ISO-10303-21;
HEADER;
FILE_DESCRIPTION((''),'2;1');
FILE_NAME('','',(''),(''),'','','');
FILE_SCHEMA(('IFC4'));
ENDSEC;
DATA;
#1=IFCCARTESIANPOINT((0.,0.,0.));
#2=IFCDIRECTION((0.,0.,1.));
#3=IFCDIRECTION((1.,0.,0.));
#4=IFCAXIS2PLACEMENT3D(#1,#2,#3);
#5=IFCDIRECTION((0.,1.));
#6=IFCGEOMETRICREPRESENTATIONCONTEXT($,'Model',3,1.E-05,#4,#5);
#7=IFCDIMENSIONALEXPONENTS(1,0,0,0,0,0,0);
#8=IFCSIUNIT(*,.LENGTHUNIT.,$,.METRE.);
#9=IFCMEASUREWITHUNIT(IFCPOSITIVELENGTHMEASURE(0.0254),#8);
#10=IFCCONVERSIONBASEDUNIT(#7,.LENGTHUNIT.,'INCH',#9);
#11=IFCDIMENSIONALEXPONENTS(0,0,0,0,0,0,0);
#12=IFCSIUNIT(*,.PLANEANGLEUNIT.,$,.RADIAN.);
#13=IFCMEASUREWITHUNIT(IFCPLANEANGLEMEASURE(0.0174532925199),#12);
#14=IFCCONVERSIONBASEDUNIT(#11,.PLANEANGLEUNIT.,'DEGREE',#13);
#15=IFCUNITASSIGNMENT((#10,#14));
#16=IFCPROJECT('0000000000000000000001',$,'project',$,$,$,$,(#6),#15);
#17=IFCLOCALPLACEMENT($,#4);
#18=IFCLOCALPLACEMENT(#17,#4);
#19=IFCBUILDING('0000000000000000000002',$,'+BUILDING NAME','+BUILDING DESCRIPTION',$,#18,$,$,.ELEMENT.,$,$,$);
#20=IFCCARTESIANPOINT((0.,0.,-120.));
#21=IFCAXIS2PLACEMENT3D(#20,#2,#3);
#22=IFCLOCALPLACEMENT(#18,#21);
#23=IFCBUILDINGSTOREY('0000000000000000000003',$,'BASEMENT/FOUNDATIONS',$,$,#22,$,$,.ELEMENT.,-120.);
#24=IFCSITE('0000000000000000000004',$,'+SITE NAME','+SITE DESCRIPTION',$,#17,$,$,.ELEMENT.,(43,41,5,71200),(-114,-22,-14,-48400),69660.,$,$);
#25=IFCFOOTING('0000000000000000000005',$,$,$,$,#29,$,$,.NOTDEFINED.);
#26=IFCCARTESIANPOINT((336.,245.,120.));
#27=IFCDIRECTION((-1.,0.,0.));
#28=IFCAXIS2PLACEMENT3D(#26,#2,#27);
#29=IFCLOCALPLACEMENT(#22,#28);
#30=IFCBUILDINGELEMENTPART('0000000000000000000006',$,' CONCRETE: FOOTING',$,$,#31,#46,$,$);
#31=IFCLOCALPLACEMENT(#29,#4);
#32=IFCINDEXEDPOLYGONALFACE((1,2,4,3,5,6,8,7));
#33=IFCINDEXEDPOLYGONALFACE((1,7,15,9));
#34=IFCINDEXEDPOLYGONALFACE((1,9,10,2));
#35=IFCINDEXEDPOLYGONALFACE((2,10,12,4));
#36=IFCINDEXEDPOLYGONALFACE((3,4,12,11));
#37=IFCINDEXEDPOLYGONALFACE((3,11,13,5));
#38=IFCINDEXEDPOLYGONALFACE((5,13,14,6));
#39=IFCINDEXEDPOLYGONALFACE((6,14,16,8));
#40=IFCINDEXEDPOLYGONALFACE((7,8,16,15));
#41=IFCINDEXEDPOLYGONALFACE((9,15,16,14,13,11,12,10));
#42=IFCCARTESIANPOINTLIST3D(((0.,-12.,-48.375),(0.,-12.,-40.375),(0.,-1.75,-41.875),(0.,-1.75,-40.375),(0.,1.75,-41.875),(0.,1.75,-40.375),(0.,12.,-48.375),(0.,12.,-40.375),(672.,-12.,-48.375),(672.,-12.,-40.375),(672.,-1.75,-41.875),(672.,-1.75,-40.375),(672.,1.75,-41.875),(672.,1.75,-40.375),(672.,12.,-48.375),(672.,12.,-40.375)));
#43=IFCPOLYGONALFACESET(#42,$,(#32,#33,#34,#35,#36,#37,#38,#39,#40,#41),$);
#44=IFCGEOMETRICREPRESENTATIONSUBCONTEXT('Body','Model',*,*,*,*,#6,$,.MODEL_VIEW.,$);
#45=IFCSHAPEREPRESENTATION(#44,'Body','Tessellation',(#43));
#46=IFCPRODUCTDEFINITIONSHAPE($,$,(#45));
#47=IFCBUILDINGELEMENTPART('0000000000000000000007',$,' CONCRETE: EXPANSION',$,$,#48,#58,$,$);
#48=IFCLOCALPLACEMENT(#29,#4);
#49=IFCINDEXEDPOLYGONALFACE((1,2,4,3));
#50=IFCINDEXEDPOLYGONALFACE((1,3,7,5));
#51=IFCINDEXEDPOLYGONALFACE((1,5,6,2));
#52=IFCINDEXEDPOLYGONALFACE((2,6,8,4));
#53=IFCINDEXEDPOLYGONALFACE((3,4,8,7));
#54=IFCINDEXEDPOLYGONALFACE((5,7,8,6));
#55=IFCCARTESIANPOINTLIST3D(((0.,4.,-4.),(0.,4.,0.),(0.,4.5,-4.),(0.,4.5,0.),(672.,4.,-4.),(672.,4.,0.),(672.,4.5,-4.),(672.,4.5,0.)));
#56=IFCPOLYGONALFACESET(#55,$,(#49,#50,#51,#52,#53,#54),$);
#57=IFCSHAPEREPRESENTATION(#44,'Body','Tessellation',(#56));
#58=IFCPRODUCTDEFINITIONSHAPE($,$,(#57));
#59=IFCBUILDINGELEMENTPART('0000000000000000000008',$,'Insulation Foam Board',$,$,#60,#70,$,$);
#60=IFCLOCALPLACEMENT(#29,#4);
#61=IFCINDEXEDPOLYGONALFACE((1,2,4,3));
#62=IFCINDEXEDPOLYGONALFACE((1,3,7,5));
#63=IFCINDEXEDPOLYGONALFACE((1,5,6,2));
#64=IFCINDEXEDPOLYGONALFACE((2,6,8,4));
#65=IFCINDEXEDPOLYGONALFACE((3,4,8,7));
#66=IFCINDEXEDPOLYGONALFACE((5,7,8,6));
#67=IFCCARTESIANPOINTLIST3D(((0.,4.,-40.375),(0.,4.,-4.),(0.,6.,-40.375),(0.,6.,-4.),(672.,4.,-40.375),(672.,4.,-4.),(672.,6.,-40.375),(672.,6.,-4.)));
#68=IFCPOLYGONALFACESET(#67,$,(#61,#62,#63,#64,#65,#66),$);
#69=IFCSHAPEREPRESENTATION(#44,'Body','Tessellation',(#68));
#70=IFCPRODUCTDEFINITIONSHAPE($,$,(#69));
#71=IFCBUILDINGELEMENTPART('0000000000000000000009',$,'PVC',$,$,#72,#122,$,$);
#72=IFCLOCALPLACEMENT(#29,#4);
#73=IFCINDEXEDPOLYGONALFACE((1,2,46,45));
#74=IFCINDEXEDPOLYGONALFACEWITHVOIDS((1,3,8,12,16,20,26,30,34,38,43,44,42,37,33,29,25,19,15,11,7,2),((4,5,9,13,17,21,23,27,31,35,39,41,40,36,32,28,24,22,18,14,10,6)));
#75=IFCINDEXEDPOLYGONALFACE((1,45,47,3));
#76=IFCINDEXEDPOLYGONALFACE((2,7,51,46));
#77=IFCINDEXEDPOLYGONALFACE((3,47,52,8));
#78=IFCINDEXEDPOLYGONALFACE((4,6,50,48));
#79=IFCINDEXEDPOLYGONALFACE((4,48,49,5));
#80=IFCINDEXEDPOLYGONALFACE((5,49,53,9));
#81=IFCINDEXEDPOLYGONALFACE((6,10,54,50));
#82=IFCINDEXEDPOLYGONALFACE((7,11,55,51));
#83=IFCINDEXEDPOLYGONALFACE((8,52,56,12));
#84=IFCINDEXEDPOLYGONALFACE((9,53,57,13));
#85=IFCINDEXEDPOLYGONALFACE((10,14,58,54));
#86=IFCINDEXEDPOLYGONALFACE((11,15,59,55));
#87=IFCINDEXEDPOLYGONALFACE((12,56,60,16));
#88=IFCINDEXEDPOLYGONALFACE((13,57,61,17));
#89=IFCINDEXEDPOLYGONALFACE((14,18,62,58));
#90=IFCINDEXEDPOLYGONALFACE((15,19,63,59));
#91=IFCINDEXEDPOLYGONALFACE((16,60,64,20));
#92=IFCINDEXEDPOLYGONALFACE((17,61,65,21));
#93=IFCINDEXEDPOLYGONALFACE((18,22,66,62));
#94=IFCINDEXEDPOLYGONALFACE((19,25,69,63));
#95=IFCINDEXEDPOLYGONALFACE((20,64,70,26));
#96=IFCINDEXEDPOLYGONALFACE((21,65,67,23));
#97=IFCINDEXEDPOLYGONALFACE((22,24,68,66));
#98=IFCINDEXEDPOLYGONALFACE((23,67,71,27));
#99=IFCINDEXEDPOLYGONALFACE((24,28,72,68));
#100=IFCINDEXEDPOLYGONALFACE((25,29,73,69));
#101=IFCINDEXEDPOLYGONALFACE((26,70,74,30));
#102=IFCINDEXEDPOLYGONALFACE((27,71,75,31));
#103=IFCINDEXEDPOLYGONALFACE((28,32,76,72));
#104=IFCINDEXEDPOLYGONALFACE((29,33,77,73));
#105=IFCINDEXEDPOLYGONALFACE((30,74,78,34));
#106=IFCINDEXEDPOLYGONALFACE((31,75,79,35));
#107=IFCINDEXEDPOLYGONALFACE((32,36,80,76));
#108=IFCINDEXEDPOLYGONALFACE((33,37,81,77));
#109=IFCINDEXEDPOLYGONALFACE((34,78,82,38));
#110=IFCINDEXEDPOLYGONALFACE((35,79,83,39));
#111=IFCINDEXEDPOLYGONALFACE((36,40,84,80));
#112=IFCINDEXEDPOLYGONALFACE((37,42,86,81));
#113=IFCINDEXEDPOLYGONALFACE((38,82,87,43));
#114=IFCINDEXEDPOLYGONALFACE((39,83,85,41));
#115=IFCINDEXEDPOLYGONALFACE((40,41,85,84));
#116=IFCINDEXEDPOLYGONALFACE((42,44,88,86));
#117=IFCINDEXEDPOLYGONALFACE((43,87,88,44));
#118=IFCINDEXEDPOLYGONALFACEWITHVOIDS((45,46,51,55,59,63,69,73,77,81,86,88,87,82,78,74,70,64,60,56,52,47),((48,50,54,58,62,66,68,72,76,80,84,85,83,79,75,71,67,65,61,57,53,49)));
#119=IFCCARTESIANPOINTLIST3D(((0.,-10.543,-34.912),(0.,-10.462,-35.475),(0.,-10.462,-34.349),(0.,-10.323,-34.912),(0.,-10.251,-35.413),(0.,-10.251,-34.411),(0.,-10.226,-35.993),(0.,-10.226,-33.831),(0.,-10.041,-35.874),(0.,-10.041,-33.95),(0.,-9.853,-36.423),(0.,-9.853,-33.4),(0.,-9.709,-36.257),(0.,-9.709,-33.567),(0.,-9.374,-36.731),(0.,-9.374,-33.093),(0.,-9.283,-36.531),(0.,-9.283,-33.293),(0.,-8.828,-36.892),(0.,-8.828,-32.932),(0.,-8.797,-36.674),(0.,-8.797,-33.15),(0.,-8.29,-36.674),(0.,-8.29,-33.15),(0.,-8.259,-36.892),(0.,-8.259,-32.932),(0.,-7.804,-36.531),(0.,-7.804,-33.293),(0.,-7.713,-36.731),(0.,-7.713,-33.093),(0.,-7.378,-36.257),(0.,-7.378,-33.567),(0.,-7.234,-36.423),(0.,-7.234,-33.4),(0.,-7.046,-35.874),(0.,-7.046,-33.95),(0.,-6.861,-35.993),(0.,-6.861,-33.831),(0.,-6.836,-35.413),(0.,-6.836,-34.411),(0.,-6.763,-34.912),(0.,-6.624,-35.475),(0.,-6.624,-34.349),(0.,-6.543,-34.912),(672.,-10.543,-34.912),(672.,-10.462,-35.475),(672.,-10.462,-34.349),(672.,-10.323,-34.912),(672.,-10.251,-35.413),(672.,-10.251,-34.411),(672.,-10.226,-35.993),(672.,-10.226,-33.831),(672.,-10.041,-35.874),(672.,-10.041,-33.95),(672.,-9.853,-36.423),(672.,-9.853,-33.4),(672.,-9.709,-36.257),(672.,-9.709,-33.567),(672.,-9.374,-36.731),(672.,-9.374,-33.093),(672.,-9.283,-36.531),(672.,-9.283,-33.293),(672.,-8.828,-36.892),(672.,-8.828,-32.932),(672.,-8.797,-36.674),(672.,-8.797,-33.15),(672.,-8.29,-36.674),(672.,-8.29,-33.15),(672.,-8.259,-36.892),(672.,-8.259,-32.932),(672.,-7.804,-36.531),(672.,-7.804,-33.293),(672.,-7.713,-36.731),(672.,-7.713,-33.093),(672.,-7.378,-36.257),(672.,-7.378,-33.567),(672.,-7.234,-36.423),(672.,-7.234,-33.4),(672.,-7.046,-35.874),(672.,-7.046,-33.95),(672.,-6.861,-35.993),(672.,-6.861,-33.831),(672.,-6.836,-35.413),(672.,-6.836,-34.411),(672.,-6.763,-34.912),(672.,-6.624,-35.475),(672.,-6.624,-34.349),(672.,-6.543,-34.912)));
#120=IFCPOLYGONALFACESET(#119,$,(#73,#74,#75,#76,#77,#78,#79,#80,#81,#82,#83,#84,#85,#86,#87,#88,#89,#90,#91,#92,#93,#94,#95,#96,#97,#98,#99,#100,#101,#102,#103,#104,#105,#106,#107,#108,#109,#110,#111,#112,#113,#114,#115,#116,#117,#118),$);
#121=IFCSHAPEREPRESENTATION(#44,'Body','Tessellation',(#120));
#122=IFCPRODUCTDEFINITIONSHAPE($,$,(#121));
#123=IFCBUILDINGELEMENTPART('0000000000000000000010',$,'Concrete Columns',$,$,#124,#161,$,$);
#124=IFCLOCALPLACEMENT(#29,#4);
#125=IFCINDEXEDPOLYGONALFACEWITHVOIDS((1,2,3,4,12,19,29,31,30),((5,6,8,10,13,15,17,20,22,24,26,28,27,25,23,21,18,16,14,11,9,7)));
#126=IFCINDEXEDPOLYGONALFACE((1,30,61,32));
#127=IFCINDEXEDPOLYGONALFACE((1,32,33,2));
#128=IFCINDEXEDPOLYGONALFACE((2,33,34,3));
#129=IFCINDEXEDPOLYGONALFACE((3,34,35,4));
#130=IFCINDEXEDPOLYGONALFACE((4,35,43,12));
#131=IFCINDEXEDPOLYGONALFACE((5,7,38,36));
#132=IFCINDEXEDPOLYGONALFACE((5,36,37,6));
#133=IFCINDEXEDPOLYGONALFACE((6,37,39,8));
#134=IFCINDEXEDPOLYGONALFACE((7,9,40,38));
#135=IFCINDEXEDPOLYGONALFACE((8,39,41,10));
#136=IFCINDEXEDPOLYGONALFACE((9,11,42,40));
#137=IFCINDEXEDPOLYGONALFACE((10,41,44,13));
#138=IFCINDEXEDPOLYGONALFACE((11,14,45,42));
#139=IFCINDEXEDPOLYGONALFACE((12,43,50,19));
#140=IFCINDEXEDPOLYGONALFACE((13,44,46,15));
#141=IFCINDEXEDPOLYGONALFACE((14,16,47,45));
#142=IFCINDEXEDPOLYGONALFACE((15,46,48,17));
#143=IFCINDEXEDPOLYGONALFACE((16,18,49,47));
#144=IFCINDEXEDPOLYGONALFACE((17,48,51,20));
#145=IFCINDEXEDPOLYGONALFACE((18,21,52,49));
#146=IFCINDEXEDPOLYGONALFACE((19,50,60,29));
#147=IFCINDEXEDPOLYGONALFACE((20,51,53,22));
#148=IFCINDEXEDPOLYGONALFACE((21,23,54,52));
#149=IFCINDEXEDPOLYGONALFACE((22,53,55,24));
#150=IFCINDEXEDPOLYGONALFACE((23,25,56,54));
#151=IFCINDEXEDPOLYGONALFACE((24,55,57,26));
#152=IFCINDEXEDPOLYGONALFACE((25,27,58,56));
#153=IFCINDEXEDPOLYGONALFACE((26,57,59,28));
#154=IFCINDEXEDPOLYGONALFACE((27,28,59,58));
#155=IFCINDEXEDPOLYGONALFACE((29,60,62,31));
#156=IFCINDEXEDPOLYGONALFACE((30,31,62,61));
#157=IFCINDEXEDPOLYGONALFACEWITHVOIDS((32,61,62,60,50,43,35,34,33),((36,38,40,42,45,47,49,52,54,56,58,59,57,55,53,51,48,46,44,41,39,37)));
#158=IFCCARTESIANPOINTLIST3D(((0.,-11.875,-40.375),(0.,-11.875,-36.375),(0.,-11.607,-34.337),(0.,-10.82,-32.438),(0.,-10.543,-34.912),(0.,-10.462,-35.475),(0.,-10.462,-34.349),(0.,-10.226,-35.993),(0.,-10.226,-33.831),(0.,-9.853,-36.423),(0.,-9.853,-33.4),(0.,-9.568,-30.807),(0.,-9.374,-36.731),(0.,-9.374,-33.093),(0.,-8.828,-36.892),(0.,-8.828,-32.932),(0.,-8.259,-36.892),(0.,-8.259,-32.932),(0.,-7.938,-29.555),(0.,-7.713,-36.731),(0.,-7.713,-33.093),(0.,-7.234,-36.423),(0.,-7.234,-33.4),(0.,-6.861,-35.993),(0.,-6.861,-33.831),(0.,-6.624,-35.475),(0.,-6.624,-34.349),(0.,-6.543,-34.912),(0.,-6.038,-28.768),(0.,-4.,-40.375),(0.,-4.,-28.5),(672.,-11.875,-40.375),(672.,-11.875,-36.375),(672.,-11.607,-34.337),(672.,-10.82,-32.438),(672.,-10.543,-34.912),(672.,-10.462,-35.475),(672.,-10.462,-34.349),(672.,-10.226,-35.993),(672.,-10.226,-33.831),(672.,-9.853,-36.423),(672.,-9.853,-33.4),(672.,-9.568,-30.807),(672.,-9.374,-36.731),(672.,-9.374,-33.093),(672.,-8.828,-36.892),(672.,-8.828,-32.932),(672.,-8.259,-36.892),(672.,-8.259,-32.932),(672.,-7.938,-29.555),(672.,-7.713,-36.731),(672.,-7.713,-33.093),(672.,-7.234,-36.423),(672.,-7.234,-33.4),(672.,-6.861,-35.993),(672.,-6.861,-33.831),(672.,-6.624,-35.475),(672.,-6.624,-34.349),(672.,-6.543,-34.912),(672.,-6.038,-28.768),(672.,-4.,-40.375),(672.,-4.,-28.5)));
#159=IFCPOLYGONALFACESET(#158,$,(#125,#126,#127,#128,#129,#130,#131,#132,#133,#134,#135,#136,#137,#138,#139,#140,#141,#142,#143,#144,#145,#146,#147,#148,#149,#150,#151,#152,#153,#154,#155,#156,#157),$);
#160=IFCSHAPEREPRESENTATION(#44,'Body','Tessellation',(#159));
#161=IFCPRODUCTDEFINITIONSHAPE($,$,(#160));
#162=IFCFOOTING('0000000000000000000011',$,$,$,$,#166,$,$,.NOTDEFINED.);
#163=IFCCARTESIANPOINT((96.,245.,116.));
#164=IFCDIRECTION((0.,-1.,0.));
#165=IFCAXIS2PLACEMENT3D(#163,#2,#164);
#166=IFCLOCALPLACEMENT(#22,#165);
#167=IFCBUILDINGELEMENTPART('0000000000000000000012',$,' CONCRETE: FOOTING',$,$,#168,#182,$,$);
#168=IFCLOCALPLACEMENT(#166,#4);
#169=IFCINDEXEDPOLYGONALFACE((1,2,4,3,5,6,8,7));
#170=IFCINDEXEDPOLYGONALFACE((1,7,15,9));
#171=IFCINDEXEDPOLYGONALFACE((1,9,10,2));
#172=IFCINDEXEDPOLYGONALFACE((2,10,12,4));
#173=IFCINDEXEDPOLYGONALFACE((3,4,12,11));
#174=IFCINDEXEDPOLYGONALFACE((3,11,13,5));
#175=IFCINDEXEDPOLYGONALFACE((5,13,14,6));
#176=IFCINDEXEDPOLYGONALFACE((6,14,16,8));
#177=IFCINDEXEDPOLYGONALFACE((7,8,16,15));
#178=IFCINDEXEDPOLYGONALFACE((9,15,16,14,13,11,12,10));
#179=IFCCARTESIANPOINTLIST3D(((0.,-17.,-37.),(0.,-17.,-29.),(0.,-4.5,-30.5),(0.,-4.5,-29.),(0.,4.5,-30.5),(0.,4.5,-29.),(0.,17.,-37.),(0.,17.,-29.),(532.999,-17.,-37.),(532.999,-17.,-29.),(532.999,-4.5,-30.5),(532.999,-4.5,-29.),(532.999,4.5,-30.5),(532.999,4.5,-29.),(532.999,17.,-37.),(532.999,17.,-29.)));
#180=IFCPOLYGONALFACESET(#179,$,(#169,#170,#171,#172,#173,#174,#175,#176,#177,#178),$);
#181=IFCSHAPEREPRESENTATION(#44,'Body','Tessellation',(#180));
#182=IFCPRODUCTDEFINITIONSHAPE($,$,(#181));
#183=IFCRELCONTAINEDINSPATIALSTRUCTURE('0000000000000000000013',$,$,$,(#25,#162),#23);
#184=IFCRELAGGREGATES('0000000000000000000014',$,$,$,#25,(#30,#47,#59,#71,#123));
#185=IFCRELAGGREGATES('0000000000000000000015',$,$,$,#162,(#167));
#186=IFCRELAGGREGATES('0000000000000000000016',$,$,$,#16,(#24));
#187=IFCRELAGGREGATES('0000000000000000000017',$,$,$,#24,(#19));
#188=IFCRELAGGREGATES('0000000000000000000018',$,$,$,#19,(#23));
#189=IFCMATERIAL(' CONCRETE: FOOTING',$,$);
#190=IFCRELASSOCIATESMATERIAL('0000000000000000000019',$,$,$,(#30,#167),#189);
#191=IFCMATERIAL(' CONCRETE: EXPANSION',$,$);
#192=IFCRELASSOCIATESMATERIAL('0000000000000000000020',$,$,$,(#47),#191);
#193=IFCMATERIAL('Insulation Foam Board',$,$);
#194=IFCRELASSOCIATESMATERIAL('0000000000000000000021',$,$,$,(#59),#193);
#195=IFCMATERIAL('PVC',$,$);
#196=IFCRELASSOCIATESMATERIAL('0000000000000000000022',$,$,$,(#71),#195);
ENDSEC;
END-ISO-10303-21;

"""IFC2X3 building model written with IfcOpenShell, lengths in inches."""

from ifc_helpers import new_model, entity, si_unit, converted_unit, point, direction, frame, frame_2d, origin_with_axes, place, context, subcontext, project, spatial, polyline, circle_curve, parameter, trimmed, segment, composite_curve, outline, extrude, material, element, aggregate, save


model = new_model("IFC2X3")

# Units and contexts
model_context = context("Model", 3, precision=1e-05, world=origin_with_axes(), true_north=direction((0.0, 1.0)))
body_context = subcontext(model_context, "Body", "Model", "MODEL_VIEW")
ifc_project = project(units=[converted_unit("LENGTHUNIT", "INCH", entity("IfcPositiveLengthMeasure", 0.0254), si_unit("LENGTHUNIT", "METRE"), dimensions=[1, 0, 0, 0, 0, 0, 0]), converted_unit("PLANEANGLEUNIT", "DEGREE", entity("IfcPlaneAngleMeasure", 0.0174532925199), si_unit("PLANEANGLEUNIT", "RADIAN"), dimensions=[0, 0, 0, 0, 0, 0, 0])], contexts=[model_context])

# Site, building, storey
site_placement = place(None, origin_with_axes())
site = spatial("IfcSite", under=ifc_project, at=site_placement, Name="+SITE NAME", Description="+SITE DESCRIPTION", CompositionType="ELEMENT", RefLatitude=(43, 41, 5, 71200), RefLongitude=(-114, -22, -14, -48400), RefElevation=69660.0)
building_placement = place(site_placement, origin_with_axes())
building = spatial("IfcBuilding", under=site, at=building_placement, Name="+BUILDING NAME", Description="+BUILDING DESCRIPTION", CompositionType="ELEMENT")
storey_placement = place(building_placement, frame((0.0, 0.0, -120.0), z_axis=(0.0, 0.0, 1.0), x_axis=(1.0, 0.0, 0.0)))
storey = spatial("IfcBuildingStorey", under=building, at=storey_placement, Name="BASEMENT/FOUNDATIONS", CompositionType="ELEMENT", Elevation=-120.0)

# Footings, building element parts
footing_1_placement = place(storey_placement, frame((336.0, 245.0, 120.0), z_axis=(0.0, 0.0, 1.0), x_axis=(-1.0, 0.0, 0.0)))
footing_1 = element("IfcFooting", 1, at=footing_1_placement, inside=storey, PredefinedType="NOTDEFINED")
ifc_material_1 = material(Name=" CONCRETE: FOOTING")
building_element_part_1_placement = place(footing_1_placement, origin_with_axes())
building_element_part_1 = element("IfcBuildingElementPart", 2, at=building_element_part_1_placement, material=ifc_material_1, Name=" CONCRETE: FOOTING", context=body_context, shape_type="SweptSolid", body=[
    extrude(outline(polyline([(-12.0, -48.375), (12.0, -48.375), (12.0, -40.375), (1.75, -40.375), (1.75, -41.875), (-1.75, -41.875), (-1.75, -40.375), (-12.0, -40.375), (-12.0, -48.375)])), frame((0.0, 0.0, 0.0), z_axis=(-1.0, 0.0, 0.0), x_axis=(0.0, -1.0, 0.0)), (0.0, 0.0, -1.0), 672.0),
])
ifc_material_2 = material(Name=" CONCRETE: EXPANSION")
building_element_part_2_placement = place(footing_1_placement, origin_with_axes())
building_element_part_2 = element("IfcBuildingElementPart", 3, at=building_element_part_2_placement, material=ifc_material_2, Name=" CONCRETE: EXPANSION", context=body_context, shape_type="SweptSolid", body=[
    extrude(outline(polyline([(-4.0, 0.0), (-4.5, 0.0), (-4.5, -4.0), (-4.0, -4.0), (-4.0, 0.0)])), frame((0.0, 0.0, 0.0), z_axis=(-1.0, 0.0, 0.0), x_axis=(0.0, -1.0, 0.0)), (0.0, 0.0, -1.0), 672.0),
])
ifc_material_3 = material(Name="Insulation Foam Board")
building_element_part_3_placement = place(footing_1_placement, origin_with_axes())
building_element_part_3 = element("IfcBuildingElementPart", 4, at=building_element_part_3_placement, material=ifc_material_3, Name="Insulation Foam Board", context=body_context, shape_type="SweptSolid", body=[
    extrude(outline(polyline([(-4.0, -4.0), (-6.0, -4.0), (-6.0, -40.375), (-4.0, -40.375), (-4.0, -4.0)])), frame((0.0, 0.0, 0.0), z_axis=(-1.0, 0.0, 0.0), x_axis=(0.0, -1.0, 0.0)), (0.0, 0.0, -1.0), 672.0),
])
ifc_material_4 = material(Name="PVC")
building_element_part_4_placement = place(footing_1_placement, origin_with_axes())
building_element_part_4 = element("IfcBuildingElementPart", 5, at=building_element_part_4_placement, material=ifc_material_4, Name="PVC", context=body_context, shape_type="SweptSolid", body=[
    extrude(outline(composite_curve([segment(trimmed(circle_curve(frame_2d((8.543, -34.912), x_axis=(1.0, 0.0)), 2.0), [point((10.543, -34.912)), parameter(0.0)], [point((6.543, -34.912)), parameter(180.0)], True, "CARTESIAN"), True, "CONTINUOUS"), segment(trimmed(circle_curve(frame_2d((8.543, -34.912), x_axis=(-1.0, 0.0)), 2.0), [point((6.543, -34.912)), parameter(0.0)], [point((10.543, -34.912)), parameter(180.0)], True, "CARTESIAN"), True, "CONTINUOUS")], self_intersect=False), holes=[composite_curve([segment(trimmed(circle_curve(frame_2d((8.543, -34.912), x_axis=(-1.0, 0.0)), 1.78), [point((10.323, -34.912)), parameter(180.0)], [point((6.763, -34.912)), parameter(0.0)], False, "CARTESIAN"), True, "CONTINUOUS"), segment(trimmed(circle_curve(frame_2d((8.543, -34.912), x_axis=(1.0, 0.0)), 1.78), [point((6.763, -34.912)), parameter(180.0)], [point((10.323, -34.912)), parameter(0.0)], False, "CARTESIAN"), True, "CONTINUOUS")], self_intersect=False)]), frame((0.0, 0.0, 0.0), z_axis=(-1.0, 0.0, 0.0), x_axis=(0.0, -1.0, 0.0)), (0.0, 0.0, -1.0), 672.0),
])
building_element_part_5_placement = place(footing_1_placement, origin_with_axes())
building_element_part_5 = element("IfcBuildingElementPart", 6, at=building_element_part_5_placement, Name="Concrete Columns", context=body_context, shape_type="SweptSolid", body=[
    extrude(outline(composite_curve([segment(trimmed(circle_curve(frame_2d((4.0, -36.375), x_axis=(1.0, 0.0)), 7.875), [point((11.875, -36.375)), parameter(0.0)], [point((4.0, -28.5)), parameter(90.0)], True, "CARTESIAN"), True, "CONTINUOUS"), segment(polyline([(4.0, -28.5), (4.0, -40.375), (11.875, -40.375), (11.875, -36.375)]), True, "CONTINUOUS")], self_intersect=False), holes=[composite_curve([segment(trimmed(circle_curve(frame_2d((8.543, -34.912), x_axis=(-1.0, 0.0)), 2.0), [point((10.543, -34.912)), parameter(180.0)], [point((6.543, -34.912)), parameter(0.0)], False, "CARTESIAN"), True, "CONTINUOUS"), segment(trimmed(circle_curve(frame_2d((8.543, -34.912), x_axis=(1.0, 0.0)), 2.0), [point((6.543, -34.912)), parameter(180.0)], [point((10.543, -34.912)), parameter(0.0)], False, "CARTESIAN"), True, "CONTINUOUS")], self_intersect=False)]), frame((0.0, 0.0, 0.0), z_axis=(-1.0, 0.0, 0.0), x_axis=(0.0, -1.0, 0.0)), (0.0, 0.0, -1.0), 672.0),
])
aggregate(footing_1, [building_element_part_1, building_element_part_2, building_element_part_3, building_element_part_4, building_element_part_5])
footing_2_placement = place(storey_placement, frame((96.0, 245.0, 116.0), z_axis=(0.0, 0.0, 1.0), x_axis=(0.0, -1.0, 0.0)))
footing_2 = element("IfcFooting", 7, at=footing_2_placement, inside=storey, PredefinedType="NOTDEFINED")
building_element_part_6_placement = place(footing_2_placement, origin_with_axes())
building_element_part_6 = element("IfcBuildingElementPart", 8, at=building_element_part_6_placement, material=ifc_material_1, Name=" CONCRETE: FOOTING", context=body_context, shape_type="SweptSolid", body=[
    extrude(outline(polyline([(-17.0, -37.0), (17.0, -37.0), (17.0, -29.0), (4.5, -29.0), (4.5, -30.5), (-4.5, -30.5), (-4.5, -29.0), (-17.0, -29.0), (-17.0, -37.0)])), frame((0.0, 0.0, 0.0), z_axis=(1.0, 0.0, 0.0), x_axis=(0.0, 1.0, 0.0)), (0.0, 0.0, 1.0), 532.999),
])
aggregate(footing_2, [building_element_part_6])

save(model, "model.ifc")
